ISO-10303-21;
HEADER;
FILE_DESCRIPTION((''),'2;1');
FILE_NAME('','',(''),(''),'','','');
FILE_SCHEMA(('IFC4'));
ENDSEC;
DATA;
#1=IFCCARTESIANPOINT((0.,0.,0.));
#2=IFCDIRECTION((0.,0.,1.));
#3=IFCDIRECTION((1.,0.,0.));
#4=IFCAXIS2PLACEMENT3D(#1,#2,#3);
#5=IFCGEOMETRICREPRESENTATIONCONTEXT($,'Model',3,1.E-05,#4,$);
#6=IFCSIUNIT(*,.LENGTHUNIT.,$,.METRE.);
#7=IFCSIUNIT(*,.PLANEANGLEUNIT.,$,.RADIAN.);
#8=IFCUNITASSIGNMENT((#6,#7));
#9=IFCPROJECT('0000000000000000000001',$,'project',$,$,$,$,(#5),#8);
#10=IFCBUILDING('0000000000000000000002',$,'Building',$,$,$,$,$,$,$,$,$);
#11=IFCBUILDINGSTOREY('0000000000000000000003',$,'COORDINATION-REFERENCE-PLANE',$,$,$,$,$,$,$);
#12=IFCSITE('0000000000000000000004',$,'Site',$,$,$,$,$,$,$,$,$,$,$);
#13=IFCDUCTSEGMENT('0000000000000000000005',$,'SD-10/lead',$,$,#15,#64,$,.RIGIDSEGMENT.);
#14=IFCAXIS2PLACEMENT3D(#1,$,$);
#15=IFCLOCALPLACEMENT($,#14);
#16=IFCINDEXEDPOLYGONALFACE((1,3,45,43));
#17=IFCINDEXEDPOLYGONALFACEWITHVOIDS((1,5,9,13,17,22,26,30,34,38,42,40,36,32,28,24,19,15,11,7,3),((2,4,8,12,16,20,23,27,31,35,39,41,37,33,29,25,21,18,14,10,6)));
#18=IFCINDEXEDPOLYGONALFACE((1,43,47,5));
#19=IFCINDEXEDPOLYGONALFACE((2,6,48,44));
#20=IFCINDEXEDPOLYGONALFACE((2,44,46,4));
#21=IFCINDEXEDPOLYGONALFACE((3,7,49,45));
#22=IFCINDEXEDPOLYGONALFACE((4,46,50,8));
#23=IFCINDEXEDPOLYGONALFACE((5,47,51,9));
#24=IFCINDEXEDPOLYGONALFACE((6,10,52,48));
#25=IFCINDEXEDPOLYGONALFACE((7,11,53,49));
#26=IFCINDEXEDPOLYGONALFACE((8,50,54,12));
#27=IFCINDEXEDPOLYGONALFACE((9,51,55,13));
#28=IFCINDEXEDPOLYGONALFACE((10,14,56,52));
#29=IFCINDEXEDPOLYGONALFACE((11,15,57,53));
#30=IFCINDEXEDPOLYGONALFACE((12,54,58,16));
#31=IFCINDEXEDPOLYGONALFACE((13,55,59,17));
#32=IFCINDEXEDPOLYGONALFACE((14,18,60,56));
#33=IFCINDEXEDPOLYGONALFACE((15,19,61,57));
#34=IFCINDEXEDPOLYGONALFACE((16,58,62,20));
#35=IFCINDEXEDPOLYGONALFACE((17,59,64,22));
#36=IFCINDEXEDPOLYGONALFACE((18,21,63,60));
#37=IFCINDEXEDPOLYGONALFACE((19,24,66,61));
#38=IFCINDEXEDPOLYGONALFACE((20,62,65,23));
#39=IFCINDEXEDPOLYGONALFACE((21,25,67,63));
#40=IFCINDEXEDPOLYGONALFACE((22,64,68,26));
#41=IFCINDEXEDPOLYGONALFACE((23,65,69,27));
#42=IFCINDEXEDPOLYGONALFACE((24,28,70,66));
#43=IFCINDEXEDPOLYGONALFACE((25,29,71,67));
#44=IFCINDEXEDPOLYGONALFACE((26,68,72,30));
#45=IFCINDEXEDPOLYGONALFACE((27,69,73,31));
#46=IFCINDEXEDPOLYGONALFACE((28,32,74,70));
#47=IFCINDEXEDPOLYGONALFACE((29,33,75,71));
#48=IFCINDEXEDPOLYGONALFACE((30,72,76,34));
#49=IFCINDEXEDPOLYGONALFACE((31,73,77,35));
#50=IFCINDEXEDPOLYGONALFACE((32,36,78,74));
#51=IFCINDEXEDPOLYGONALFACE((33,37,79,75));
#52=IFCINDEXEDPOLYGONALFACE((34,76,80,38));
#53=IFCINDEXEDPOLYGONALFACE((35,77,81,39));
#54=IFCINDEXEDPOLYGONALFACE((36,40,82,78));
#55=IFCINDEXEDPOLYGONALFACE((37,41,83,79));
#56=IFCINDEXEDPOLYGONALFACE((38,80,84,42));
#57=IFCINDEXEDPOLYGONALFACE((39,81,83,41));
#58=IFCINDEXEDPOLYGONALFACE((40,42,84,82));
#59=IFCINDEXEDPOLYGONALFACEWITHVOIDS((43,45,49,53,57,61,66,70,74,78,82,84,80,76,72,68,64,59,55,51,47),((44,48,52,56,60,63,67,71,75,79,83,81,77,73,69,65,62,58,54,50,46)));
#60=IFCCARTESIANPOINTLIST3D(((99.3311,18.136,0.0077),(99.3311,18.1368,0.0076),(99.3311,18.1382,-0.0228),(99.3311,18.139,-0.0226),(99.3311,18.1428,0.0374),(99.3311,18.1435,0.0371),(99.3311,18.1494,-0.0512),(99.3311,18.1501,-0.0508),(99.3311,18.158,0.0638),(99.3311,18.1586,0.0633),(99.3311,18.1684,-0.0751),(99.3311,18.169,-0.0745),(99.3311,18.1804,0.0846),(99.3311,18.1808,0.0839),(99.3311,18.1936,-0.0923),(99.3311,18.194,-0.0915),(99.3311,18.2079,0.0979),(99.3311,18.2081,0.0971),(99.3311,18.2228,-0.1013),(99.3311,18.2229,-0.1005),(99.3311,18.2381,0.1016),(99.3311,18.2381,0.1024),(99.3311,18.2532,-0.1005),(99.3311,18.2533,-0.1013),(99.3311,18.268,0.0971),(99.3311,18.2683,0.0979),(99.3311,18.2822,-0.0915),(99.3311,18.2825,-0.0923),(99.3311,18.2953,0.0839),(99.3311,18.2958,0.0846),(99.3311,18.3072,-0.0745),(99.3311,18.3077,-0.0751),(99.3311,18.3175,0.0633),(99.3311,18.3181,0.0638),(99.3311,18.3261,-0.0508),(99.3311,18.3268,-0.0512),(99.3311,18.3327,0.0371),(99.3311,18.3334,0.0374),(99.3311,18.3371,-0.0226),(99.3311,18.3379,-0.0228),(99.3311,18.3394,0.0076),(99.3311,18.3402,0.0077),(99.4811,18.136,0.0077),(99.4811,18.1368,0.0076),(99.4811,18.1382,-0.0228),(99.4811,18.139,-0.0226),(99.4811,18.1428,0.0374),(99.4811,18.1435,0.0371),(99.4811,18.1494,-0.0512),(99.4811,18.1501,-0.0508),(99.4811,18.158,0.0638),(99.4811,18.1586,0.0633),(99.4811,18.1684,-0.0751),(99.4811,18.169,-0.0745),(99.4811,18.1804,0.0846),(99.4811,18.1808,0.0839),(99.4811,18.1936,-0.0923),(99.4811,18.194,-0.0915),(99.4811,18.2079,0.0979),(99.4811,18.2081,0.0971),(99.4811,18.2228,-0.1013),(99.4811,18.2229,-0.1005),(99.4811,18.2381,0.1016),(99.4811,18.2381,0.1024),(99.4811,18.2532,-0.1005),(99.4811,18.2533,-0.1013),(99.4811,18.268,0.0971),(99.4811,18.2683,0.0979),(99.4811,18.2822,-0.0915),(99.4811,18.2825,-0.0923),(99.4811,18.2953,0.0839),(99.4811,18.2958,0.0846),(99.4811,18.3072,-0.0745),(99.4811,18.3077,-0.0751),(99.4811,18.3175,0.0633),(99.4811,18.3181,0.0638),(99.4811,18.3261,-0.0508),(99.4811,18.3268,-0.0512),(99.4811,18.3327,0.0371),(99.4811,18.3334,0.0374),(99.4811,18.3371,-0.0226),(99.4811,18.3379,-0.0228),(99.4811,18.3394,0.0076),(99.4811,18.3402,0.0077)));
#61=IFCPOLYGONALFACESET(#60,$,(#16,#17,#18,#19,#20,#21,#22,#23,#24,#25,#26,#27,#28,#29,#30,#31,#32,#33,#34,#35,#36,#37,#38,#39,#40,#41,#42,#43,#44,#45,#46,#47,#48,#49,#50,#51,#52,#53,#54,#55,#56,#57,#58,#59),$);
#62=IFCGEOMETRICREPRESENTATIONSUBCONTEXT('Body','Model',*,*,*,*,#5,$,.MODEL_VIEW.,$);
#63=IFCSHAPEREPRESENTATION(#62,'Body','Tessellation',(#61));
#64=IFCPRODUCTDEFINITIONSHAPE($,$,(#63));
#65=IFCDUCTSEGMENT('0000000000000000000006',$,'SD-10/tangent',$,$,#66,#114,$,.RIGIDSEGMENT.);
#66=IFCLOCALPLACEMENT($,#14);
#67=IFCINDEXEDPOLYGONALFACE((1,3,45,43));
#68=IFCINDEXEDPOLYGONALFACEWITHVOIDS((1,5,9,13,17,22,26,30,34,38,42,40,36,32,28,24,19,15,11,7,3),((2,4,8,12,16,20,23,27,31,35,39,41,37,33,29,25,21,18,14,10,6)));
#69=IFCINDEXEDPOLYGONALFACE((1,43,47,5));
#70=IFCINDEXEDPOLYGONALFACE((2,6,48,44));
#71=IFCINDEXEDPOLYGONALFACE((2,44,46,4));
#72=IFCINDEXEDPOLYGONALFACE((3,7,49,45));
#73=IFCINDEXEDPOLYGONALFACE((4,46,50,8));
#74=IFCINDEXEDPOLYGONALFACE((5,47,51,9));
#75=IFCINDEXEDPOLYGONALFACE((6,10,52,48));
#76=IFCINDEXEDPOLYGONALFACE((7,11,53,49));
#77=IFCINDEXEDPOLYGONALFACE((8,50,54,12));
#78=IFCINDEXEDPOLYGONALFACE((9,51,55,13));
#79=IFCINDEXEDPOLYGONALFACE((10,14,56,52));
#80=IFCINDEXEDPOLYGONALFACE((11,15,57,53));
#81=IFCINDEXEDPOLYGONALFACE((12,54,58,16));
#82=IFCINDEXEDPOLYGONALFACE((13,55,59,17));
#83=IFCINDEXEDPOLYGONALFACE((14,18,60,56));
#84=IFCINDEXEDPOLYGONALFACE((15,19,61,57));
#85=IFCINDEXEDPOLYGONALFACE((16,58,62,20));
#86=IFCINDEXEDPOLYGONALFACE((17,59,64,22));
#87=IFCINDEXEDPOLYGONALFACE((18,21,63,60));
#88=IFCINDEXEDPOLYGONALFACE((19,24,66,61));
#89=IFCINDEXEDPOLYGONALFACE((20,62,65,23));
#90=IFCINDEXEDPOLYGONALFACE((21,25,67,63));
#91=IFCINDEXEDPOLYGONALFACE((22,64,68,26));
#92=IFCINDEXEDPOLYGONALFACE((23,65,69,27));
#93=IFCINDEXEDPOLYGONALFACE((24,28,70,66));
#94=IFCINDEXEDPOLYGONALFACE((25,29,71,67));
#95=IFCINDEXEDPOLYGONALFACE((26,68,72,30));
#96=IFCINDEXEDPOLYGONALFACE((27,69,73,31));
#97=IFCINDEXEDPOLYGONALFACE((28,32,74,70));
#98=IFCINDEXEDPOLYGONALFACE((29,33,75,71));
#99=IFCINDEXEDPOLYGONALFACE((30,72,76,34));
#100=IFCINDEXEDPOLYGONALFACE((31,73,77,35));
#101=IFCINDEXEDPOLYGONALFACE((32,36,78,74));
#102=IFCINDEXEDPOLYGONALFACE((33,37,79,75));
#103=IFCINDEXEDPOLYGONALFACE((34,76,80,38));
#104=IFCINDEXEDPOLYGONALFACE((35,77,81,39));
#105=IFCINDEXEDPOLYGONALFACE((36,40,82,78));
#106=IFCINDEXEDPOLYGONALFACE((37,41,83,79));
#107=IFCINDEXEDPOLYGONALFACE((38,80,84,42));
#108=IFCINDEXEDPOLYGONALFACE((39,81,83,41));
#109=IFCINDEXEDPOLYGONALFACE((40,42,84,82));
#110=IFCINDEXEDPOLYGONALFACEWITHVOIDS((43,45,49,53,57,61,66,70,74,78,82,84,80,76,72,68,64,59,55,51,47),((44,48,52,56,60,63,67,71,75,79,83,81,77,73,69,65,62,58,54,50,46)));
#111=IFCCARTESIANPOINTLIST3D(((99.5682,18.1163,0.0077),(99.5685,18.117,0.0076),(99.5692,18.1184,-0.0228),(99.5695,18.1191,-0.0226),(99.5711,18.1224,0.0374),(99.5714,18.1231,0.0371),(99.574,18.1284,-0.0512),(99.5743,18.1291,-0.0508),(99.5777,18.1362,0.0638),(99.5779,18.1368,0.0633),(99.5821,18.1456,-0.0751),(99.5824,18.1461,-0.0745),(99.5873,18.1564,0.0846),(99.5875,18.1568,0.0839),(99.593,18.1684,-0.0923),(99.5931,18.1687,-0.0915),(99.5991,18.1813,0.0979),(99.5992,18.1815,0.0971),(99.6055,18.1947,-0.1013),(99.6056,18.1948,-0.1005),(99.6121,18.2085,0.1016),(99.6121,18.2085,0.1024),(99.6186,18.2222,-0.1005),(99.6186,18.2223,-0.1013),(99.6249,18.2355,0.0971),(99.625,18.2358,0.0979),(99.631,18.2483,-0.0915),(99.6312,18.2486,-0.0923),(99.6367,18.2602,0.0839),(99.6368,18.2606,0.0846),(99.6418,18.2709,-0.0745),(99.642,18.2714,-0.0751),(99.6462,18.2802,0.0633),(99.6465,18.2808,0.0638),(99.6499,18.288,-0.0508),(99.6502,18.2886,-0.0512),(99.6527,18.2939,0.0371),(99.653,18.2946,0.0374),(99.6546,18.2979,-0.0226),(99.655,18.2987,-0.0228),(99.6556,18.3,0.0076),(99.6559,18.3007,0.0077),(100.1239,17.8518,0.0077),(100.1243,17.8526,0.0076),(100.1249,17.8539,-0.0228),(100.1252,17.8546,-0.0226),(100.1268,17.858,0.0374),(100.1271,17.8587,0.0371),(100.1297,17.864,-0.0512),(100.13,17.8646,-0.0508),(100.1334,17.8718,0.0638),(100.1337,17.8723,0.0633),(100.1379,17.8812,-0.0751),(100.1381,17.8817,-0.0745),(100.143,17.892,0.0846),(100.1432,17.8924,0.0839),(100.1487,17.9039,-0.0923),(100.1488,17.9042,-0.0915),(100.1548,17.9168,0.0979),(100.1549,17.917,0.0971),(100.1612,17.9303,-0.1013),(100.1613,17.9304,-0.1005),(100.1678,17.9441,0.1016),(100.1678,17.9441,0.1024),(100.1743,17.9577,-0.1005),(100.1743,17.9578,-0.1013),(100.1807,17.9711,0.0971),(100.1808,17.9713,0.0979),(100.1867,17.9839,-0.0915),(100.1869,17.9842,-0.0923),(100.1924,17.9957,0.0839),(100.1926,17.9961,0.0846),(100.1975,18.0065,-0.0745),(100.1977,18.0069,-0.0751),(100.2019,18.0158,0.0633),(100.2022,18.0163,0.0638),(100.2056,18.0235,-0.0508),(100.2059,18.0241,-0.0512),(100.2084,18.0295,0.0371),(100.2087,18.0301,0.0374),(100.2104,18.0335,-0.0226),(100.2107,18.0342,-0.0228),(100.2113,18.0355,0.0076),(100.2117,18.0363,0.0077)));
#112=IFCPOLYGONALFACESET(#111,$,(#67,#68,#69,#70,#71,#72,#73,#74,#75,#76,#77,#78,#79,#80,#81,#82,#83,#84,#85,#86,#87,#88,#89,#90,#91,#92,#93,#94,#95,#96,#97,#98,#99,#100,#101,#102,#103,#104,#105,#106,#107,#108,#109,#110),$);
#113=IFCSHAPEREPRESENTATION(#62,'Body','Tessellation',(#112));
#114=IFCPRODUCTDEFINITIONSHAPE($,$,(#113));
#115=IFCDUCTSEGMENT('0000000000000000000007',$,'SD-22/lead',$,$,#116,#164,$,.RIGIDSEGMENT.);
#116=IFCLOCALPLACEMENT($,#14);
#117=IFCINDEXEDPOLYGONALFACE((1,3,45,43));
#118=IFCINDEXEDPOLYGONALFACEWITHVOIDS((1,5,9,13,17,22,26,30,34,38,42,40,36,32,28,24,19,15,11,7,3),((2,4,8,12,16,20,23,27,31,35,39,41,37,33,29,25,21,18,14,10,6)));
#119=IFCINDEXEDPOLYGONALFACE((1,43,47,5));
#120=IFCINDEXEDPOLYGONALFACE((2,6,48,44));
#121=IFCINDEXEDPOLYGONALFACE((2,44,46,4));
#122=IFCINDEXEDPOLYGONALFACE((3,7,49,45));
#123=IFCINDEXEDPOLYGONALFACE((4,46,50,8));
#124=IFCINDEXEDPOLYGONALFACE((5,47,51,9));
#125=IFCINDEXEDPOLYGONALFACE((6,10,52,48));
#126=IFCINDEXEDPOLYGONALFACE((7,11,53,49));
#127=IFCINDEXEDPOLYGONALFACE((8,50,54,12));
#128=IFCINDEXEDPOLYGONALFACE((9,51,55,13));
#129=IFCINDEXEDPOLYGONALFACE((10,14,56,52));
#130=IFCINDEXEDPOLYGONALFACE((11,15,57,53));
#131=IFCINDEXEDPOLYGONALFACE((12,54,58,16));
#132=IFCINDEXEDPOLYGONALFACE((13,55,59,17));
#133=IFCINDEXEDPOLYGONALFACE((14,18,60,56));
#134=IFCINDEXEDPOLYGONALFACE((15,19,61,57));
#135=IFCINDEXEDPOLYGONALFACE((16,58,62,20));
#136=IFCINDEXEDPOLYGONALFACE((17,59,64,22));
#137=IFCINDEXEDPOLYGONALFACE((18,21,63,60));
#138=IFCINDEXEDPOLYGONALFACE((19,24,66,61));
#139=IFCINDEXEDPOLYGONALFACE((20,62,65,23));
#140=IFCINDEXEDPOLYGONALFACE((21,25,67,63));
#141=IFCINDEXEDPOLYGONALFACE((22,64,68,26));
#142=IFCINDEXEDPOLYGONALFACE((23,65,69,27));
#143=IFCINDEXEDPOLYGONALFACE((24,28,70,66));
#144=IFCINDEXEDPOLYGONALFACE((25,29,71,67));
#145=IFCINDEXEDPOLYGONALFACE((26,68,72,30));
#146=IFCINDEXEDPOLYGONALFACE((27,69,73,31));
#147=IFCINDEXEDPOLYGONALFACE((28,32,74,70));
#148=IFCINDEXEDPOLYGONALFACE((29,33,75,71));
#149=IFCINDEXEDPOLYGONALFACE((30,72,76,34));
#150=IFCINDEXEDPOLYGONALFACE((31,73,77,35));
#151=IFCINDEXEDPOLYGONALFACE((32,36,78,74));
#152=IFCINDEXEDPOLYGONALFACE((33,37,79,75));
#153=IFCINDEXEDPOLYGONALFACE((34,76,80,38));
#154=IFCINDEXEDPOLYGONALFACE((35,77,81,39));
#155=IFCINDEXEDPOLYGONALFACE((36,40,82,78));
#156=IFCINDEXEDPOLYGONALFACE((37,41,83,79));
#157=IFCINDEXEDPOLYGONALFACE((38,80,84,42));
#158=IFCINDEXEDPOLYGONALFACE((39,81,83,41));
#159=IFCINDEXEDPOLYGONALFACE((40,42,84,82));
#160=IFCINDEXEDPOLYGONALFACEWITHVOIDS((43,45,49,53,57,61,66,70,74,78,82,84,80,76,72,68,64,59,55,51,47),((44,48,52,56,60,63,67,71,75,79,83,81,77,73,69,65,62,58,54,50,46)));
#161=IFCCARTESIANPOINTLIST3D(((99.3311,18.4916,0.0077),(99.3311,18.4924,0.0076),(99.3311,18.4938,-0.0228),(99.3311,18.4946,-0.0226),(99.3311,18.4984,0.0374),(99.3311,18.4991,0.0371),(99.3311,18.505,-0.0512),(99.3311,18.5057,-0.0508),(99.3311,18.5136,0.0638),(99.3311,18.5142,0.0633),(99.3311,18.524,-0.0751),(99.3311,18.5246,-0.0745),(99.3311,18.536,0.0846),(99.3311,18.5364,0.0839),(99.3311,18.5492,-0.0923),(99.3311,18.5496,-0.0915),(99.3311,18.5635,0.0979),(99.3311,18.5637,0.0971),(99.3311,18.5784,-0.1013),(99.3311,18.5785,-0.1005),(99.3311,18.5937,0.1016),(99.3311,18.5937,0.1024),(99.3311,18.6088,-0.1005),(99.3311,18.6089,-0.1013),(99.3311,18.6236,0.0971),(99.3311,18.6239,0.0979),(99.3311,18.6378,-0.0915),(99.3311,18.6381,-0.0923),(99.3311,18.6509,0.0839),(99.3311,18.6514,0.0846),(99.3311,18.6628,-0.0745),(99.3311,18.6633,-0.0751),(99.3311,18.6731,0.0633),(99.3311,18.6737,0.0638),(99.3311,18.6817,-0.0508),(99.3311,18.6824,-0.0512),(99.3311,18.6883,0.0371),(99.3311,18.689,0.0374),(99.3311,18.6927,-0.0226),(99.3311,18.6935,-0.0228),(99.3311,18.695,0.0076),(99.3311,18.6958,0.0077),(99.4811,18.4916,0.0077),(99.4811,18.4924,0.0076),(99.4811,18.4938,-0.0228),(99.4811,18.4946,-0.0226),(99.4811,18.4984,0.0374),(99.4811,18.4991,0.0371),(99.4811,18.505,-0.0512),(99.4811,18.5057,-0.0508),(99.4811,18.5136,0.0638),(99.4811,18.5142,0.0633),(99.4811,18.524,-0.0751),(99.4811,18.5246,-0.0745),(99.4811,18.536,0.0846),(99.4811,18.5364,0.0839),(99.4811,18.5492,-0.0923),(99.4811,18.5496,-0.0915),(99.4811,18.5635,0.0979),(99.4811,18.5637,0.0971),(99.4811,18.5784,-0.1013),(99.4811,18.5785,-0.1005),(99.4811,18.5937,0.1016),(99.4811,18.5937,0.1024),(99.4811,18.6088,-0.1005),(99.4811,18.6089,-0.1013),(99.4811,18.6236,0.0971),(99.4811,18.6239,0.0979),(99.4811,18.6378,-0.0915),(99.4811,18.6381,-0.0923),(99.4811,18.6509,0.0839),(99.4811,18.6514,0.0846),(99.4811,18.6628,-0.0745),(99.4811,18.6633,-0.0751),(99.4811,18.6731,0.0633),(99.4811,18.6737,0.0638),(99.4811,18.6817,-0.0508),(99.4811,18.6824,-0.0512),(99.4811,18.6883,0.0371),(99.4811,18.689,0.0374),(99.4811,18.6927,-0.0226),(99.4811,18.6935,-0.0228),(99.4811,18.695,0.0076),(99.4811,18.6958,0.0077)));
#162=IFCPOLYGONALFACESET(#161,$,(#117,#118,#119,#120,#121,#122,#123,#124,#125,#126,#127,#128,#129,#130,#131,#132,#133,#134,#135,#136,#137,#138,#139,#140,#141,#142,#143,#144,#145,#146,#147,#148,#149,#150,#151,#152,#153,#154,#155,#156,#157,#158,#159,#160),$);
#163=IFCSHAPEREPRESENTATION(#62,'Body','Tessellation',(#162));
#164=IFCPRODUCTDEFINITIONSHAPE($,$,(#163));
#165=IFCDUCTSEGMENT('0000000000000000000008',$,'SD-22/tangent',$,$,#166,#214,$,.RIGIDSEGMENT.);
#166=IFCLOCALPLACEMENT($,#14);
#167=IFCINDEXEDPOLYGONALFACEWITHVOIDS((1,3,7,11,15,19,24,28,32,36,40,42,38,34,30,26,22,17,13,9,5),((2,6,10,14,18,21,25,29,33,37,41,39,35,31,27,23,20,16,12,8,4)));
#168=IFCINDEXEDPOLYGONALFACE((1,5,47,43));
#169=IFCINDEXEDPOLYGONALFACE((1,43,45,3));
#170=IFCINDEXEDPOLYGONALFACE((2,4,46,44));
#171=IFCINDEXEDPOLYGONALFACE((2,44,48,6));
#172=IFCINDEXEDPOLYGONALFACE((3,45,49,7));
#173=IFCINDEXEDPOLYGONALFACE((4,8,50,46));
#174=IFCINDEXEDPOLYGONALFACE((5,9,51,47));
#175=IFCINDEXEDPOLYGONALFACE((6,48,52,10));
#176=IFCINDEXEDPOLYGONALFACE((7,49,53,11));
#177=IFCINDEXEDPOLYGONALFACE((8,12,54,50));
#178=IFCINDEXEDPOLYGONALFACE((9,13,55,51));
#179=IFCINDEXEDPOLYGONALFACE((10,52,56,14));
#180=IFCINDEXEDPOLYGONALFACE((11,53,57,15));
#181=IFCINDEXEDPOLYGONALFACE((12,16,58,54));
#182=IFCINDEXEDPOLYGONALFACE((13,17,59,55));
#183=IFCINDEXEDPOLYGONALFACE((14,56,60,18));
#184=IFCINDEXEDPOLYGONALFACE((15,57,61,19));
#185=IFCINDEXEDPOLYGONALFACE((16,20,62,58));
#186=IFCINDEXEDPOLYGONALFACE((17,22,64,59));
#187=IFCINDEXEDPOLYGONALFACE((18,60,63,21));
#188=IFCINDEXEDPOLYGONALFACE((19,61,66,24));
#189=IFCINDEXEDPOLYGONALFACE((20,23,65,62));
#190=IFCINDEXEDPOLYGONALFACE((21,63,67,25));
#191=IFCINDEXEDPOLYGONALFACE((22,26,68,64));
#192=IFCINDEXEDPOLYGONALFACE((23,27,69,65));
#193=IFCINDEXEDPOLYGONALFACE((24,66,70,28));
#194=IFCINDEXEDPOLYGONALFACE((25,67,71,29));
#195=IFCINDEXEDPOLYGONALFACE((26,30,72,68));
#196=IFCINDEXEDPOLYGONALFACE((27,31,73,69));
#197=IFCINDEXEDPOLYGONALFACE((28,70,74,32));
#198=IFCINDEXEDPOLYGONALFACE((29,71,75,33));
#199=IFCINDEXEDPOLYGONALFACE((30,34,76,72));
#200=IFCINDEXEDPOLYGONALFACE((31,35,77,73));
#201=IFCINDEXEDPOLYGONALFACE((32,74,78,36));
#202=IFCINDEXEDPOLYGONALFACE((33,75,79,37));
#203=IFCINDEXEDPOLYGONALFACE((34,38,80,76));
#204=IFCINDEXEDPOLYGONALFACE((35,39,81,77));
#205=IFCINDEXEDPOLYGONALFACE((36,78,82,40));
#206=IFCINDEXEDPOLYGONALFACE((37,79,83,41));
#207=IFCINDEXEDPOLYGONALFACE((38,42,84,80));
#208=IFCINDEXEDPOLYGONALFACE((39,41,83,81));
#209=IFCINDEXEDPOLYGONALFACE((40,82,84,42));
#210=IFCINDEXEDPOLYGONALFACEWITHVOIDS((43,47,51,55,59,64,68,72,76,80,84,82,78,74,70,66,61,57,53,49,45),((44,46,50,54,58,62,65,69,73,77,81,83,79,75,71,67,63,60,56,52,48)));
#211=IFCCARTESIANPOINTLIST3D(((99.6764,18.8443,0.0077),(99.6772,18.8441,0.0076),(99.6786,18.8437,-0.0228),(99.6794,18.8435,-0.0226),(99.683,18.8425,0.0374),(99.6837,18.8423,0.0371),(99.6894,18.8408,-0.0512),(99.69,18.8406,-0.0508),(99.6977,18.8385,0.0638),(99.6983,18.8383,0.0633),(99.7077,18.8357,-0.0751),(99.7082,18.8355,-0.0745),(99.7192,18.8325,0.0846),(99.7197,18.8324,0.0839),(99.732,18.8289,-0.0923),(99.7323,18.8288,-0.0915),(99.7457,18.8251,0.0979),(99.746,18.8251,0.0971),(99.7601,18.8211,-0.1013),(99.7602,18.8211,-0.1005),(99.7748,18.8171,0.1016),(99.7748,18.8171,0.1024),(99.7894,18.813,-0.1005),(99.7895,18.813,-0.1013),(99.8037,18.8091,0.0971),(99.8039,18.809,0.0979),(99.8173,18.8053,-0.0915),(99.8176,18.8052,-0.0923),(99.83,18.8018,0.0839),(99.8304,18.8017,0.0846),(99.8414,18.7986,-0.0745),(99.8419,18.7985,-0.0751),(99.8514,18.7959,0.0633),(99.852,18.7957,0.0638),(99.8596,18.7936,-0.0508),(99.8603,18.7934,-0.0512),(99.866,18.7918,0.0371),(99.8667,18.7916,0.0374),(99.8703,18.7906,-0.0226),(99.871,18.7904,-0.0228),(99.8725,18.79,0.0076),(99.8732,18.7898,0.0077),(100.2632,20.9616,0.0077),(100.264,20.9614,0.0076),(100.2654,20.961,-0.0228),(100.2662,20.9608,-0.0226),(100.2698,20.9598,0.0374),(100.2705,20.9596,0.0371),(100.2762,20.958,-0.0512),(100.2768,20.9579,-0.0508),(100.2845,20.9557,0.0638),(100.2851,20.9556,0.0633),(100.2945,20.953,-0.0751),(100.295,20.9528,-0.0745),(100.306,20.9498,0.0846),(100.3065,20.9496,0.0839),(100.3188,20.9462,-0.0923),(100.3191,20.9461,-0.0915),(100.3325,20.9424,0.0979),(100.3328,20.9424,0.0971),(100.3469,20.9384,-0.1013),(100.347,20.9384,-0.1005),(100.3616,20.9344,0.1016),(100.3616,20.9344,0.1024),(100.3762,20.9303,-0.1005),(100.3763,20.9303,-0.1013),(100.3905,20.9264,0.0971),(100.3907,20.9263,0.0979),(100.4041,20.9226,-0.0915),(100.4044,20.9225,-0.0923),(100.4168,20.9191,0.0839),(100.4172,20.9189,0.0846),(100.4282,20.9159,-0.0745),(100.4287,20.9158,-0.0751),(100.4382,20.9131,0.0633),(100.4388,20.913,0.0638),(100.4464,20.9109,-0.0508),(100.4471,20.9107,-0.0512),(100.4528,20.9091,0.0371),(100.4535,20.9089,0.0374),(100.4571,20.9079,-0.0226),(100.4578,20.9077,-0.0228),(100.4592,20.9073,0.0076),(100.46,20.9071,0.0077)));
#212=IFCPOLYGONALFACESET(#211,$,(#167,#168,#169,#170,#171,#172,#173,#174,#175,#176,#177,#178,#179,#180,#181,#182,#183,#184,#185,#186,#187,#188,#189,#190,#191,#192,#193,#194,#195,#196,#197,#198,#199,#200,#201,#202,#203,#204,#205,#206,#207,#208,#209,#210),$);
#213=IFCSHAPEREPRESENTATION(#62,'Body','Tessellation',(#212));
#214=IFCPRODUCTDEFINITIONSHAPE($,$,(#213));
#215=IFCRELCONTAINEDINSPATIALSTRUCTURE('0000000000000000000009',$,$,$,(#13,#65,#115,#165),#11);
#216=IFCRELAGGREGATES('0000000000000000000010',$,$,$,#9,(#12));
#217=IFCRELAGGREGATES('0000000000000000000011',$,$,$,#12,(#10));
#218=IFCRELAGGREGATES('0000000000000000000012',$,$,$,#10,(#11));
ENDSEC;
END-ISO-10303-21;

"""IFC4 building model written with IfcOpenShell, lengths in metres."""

from ifc_helpers import new_model, si_unit, frame, origin_with_axes, place, context, subcontext, project, spatial, hollow_circle, extrude, element, save


model = new_model("IFC4")

# Units and contexts
model_context_1 = context("Model", 3, precision=1e-05, world=origin_with_axes())
body_context_1 = subcontext(model_context_1, "Body", "Model", "MODEL_VIEW")
ifc_project = project(units=[si_unit("LENGTHUNIT", "METRE"), si_unit("PLANEANGLEUNIT", "RADIAN")], contexts=[model_context_1])

# Site, building, storey
site = spatial("IfcSite", under=ifc_project, Name="Site")
building = spatial("IfcBuilding", under=site, Name="Building")
storey = spatial("IfcBuildingStorey", under=building, Name="COORDINATION-REFERENCE-PLANE")

# Duct segment
duct_segment_1_placement = place(None, frame((99.3311, 18.2381, 0.0), z_axis=(1.0, 0.0, 0.0), x_axis=(0.0, 0.0, 1.0)))
element("IfcDuctSegment", 1, at=duct_segment_1_placement, inside=storey, Name="SD-10/lead", PredefinedType="RIGIDSEGMENT", context=body_context_1, shape_type="SweptSolid", body=[
    extrude(hollow_circle(Radius=0.1024, WallThickness=0.0008), origin_with_axes(), (0.0, 0.0, 1.0), 0.15),
])

# Duct segment
duct_segment_2_placement = place(None, frame((99.6121, 18.2085, 0.0), z_axis=(0.902975, -0.429693, 0.0), x_axis=(0.0, 0.0, 1.0)))
element("IfcDuctSegment", 2, at=duct_segment_2_placement, inside=storey, Name="SD-10/tangent", PredefinedType="RIGIDSEGMENT", context=body_context_1, shape_type="SweptSolid", body=[
    extrude(hollow_circle(Radius=0.1024, WallThickness=0.0008), origin_with_axes(), (0.0, 0.0, 1.0), 0.6154),
])

# Duct segment
duct_segment_3_placement = place(None, frame((99.3311, 18.5937, 0.0), z_axis=(1.0, 0.0, 0.0), x_axis=(0.0, 0.0, 1.0)))
element("IfcDuctSegment", 3, at=duct_segment_3_placement, inside=storey, Name="SD-22/lead", PredefinedType="RIGIDSEGMENT", context=body_context_1, shape_type="SweptSolid", body=[
    extrude(hollow_circle(Radius=0.1024, WallThickness=0.0008), origin_with_axes(), (0.0, 0.0, 1.0), 0.15),
])

# Duct segment
duct_segment_4_placement = place(None, frame((99.7748, 18.8171, 0.0), z_axis=(0.267077, 0.963675, 0.0), x_axis=(0.0, 0.0, 1.0)))
element("IfcDuctSegment", 4, at=duct_segment_4_placement, inside=storey, Name="SD-22/tangent", PredefinedType="RIGIDSEGMENT", context=body_context_1, shape_type="SweptSolid", body=[
    extrude(hollow_circle(Radius=0.1024, WallThickness=0.0008), origin_with_axes(), (0.0, 0.0, 1.0), 2.1971),
])

save(model, "model.ifc")
